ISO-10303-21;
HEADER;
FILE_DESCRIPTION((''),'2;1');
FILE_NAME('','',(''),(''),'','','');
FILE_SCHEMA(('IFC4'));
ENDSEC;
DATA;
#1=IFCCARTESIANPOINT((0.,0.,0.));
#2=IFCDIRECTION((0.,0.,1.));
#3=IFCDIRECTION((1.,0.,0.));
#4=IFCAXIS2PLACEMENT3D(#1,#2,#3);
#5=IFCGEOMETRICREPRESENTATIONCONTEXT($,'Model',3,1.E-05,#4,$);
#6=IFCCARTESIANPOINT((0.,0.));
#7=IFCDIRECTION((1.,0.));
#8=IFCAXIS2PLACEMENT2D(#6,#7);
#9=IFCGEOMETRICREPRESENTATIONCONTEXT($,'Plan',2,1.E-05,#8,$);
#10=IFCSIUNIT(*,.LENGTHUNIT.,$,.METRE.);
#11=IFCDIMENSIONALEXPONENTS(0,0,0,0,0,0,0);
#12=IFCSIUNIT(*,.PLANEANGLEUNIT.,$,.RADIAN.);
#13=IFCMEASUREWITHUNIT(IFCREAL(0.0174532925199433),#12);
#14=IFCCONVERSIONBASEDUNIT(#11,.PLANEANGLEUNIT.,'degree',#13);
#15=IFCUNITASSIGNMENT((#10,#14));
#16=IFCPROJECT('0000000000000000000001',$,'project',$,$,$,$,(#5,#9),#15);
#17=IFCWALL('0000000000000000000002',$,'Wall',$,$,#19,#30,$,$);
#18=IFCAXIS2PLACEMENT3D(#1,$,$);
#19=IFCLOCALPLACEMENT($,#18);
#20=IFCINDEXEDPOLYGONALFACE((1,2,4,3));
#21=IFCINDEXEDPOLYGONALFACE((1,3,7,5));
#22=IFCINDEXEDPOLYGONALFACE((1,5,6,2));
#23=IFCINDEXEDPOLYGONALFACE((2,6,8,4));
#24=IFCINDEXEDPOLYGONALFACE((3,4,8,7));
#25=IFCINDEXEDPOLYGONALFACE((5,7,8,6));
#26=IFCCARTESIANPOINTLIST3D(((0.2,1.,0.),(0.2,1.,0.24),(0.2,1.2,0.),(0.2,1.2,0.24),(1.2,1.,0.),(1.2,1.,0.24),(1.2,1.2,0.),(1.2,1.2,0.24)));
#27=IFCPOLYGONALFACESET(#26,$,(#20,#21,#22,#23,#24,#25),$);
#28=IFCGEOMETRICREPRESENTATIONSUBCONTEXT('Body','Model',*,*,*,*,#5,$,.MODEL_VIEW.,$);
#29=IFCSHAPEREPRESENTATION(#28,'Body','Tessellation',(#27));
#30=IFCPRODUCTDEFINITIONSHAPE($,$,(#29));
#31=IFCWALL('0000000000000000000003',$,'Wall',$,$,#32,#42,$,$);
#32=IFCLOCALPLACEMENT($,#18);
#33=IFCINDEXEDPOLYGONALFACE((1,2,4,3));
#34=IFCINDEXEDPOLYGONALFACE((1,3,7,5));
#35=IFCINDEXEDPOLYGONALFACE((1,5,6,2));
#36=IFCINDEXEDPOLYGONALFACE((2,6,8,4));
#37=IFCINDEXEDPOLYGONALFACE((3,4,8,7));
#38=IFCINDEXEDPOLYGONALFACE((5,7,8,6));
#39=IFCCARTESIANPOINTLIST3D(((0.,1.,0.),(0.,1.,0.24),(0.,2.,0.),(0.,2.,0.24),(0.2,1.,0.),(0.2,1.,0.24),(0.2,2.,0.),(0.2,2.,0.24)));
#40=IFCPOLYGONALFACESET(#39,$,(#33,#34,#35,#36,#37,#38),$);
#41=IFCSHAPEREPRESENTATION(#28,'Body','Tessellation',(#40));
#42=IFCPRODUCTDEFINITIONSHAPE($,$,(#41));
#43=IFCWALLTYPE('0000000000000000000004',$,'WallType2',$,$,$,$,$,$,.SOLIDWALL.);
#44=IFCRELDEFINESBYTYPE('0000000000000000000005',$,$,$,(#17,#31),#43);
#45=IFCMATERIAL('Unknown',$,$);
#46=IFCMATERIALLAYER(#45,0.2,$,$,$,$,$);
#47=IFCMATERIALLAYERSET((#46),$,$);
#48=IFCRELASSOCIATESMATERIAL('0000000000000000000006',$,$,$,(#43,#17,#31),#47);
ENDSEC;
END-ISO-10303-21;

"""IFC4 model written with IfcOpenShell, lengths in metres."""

from ifc_helpers import new_model, entity, si_unit, converted_unit, frame, origin_with_axes, origin_2d_with_axis, place, context, subcontext, project, indexed_curve, outline, extrude, material, layer, layer_set, layer_usage, type_object, element, save


model = new_model("IFC4")

# Units and contexts
model_context = context("Model", 3, precision=1e-05, world=origin_with_axes())
plan_context = context("Plan", 2, precision=1e-05, world=origin_2d_with_axis())
body_context = subcontext(model_context, "Body", "Model", "MODEL_VIEW")
ifc_project = project(units=[si_unit("LENGTHUNIT", "METRE"), converted_unit("PLANEANGLEUNIT", "degree", entity("IfcReal", 0.0174532925199433), si_unit("PLANEANGLEUNIT", "RADIAN"), dimensions=[0, 0, 0, 0, 0, 0, 0])], contexts=[model_context, plan_context])

# Walls
ifc_material = material(Name="Unknown")
ifc_layer = layer(ifc_material, 0.2)
ifc_layer_set = layer_set([ifc_layer])
ifc_layer_usage_1 = layer_usage(ifc_layer_set, "AXIS2", "POSITIVE", 0.0)
wall_type = type_object("IfcWallType", Name="WallType2", PredefinedType="SOLIDWALL", material=ifc_layer_set)
wall_1_placement = place(None, frame((0.2, 1.0, 0.0), z_axis=(0.0, 0.0, 1.0), x_axis=(1.0, 0.0, 0.0)))
element("IfcWall", 1, at=wall_1_placement, type_object=wall_type, material=ifc_layer_usage_1, Name="Wall", context=body_context, shape_type="SweptSolid", body=[
    extrude(outline(indexed_curve([(0.0, 0.0), (0.0, 0.2), (1.0, 0.2), (1.0, 0.0), (0.0, 0.0)], self_intersect=False)), origin_with_axes(), (0.0, 0.0, 1.0), 0.24),
])
ifc_layer_usage_2 = layer_usage(ifc_layer_set, "AXIS2", "POSITIVE", 0.0)
wall_2_placement = place(None, frame((0.0, 2.0, 0.0), z_axis=(0.0, 0.0, 1.0), x_axis=(0.0, -1.0, 0.0)))
element("IfcWall", 2, at=wall_2_placement, type_object=wall_type, material=ifc_layer_usage_2, Name="Wall", context=body_context, shape_type="SweptSolid", body=[
    extrude(outline(indexed_curve([(0.0, 0.0), (0.0, 0.2), (1.0, 0.2), (1.0, 0.0), (0.0, 0.0)], self_intersect=False)), origin_with_axes(), (0.0, 0.0, 1.0), 0.24),
])

save(model, "model.ifc")
